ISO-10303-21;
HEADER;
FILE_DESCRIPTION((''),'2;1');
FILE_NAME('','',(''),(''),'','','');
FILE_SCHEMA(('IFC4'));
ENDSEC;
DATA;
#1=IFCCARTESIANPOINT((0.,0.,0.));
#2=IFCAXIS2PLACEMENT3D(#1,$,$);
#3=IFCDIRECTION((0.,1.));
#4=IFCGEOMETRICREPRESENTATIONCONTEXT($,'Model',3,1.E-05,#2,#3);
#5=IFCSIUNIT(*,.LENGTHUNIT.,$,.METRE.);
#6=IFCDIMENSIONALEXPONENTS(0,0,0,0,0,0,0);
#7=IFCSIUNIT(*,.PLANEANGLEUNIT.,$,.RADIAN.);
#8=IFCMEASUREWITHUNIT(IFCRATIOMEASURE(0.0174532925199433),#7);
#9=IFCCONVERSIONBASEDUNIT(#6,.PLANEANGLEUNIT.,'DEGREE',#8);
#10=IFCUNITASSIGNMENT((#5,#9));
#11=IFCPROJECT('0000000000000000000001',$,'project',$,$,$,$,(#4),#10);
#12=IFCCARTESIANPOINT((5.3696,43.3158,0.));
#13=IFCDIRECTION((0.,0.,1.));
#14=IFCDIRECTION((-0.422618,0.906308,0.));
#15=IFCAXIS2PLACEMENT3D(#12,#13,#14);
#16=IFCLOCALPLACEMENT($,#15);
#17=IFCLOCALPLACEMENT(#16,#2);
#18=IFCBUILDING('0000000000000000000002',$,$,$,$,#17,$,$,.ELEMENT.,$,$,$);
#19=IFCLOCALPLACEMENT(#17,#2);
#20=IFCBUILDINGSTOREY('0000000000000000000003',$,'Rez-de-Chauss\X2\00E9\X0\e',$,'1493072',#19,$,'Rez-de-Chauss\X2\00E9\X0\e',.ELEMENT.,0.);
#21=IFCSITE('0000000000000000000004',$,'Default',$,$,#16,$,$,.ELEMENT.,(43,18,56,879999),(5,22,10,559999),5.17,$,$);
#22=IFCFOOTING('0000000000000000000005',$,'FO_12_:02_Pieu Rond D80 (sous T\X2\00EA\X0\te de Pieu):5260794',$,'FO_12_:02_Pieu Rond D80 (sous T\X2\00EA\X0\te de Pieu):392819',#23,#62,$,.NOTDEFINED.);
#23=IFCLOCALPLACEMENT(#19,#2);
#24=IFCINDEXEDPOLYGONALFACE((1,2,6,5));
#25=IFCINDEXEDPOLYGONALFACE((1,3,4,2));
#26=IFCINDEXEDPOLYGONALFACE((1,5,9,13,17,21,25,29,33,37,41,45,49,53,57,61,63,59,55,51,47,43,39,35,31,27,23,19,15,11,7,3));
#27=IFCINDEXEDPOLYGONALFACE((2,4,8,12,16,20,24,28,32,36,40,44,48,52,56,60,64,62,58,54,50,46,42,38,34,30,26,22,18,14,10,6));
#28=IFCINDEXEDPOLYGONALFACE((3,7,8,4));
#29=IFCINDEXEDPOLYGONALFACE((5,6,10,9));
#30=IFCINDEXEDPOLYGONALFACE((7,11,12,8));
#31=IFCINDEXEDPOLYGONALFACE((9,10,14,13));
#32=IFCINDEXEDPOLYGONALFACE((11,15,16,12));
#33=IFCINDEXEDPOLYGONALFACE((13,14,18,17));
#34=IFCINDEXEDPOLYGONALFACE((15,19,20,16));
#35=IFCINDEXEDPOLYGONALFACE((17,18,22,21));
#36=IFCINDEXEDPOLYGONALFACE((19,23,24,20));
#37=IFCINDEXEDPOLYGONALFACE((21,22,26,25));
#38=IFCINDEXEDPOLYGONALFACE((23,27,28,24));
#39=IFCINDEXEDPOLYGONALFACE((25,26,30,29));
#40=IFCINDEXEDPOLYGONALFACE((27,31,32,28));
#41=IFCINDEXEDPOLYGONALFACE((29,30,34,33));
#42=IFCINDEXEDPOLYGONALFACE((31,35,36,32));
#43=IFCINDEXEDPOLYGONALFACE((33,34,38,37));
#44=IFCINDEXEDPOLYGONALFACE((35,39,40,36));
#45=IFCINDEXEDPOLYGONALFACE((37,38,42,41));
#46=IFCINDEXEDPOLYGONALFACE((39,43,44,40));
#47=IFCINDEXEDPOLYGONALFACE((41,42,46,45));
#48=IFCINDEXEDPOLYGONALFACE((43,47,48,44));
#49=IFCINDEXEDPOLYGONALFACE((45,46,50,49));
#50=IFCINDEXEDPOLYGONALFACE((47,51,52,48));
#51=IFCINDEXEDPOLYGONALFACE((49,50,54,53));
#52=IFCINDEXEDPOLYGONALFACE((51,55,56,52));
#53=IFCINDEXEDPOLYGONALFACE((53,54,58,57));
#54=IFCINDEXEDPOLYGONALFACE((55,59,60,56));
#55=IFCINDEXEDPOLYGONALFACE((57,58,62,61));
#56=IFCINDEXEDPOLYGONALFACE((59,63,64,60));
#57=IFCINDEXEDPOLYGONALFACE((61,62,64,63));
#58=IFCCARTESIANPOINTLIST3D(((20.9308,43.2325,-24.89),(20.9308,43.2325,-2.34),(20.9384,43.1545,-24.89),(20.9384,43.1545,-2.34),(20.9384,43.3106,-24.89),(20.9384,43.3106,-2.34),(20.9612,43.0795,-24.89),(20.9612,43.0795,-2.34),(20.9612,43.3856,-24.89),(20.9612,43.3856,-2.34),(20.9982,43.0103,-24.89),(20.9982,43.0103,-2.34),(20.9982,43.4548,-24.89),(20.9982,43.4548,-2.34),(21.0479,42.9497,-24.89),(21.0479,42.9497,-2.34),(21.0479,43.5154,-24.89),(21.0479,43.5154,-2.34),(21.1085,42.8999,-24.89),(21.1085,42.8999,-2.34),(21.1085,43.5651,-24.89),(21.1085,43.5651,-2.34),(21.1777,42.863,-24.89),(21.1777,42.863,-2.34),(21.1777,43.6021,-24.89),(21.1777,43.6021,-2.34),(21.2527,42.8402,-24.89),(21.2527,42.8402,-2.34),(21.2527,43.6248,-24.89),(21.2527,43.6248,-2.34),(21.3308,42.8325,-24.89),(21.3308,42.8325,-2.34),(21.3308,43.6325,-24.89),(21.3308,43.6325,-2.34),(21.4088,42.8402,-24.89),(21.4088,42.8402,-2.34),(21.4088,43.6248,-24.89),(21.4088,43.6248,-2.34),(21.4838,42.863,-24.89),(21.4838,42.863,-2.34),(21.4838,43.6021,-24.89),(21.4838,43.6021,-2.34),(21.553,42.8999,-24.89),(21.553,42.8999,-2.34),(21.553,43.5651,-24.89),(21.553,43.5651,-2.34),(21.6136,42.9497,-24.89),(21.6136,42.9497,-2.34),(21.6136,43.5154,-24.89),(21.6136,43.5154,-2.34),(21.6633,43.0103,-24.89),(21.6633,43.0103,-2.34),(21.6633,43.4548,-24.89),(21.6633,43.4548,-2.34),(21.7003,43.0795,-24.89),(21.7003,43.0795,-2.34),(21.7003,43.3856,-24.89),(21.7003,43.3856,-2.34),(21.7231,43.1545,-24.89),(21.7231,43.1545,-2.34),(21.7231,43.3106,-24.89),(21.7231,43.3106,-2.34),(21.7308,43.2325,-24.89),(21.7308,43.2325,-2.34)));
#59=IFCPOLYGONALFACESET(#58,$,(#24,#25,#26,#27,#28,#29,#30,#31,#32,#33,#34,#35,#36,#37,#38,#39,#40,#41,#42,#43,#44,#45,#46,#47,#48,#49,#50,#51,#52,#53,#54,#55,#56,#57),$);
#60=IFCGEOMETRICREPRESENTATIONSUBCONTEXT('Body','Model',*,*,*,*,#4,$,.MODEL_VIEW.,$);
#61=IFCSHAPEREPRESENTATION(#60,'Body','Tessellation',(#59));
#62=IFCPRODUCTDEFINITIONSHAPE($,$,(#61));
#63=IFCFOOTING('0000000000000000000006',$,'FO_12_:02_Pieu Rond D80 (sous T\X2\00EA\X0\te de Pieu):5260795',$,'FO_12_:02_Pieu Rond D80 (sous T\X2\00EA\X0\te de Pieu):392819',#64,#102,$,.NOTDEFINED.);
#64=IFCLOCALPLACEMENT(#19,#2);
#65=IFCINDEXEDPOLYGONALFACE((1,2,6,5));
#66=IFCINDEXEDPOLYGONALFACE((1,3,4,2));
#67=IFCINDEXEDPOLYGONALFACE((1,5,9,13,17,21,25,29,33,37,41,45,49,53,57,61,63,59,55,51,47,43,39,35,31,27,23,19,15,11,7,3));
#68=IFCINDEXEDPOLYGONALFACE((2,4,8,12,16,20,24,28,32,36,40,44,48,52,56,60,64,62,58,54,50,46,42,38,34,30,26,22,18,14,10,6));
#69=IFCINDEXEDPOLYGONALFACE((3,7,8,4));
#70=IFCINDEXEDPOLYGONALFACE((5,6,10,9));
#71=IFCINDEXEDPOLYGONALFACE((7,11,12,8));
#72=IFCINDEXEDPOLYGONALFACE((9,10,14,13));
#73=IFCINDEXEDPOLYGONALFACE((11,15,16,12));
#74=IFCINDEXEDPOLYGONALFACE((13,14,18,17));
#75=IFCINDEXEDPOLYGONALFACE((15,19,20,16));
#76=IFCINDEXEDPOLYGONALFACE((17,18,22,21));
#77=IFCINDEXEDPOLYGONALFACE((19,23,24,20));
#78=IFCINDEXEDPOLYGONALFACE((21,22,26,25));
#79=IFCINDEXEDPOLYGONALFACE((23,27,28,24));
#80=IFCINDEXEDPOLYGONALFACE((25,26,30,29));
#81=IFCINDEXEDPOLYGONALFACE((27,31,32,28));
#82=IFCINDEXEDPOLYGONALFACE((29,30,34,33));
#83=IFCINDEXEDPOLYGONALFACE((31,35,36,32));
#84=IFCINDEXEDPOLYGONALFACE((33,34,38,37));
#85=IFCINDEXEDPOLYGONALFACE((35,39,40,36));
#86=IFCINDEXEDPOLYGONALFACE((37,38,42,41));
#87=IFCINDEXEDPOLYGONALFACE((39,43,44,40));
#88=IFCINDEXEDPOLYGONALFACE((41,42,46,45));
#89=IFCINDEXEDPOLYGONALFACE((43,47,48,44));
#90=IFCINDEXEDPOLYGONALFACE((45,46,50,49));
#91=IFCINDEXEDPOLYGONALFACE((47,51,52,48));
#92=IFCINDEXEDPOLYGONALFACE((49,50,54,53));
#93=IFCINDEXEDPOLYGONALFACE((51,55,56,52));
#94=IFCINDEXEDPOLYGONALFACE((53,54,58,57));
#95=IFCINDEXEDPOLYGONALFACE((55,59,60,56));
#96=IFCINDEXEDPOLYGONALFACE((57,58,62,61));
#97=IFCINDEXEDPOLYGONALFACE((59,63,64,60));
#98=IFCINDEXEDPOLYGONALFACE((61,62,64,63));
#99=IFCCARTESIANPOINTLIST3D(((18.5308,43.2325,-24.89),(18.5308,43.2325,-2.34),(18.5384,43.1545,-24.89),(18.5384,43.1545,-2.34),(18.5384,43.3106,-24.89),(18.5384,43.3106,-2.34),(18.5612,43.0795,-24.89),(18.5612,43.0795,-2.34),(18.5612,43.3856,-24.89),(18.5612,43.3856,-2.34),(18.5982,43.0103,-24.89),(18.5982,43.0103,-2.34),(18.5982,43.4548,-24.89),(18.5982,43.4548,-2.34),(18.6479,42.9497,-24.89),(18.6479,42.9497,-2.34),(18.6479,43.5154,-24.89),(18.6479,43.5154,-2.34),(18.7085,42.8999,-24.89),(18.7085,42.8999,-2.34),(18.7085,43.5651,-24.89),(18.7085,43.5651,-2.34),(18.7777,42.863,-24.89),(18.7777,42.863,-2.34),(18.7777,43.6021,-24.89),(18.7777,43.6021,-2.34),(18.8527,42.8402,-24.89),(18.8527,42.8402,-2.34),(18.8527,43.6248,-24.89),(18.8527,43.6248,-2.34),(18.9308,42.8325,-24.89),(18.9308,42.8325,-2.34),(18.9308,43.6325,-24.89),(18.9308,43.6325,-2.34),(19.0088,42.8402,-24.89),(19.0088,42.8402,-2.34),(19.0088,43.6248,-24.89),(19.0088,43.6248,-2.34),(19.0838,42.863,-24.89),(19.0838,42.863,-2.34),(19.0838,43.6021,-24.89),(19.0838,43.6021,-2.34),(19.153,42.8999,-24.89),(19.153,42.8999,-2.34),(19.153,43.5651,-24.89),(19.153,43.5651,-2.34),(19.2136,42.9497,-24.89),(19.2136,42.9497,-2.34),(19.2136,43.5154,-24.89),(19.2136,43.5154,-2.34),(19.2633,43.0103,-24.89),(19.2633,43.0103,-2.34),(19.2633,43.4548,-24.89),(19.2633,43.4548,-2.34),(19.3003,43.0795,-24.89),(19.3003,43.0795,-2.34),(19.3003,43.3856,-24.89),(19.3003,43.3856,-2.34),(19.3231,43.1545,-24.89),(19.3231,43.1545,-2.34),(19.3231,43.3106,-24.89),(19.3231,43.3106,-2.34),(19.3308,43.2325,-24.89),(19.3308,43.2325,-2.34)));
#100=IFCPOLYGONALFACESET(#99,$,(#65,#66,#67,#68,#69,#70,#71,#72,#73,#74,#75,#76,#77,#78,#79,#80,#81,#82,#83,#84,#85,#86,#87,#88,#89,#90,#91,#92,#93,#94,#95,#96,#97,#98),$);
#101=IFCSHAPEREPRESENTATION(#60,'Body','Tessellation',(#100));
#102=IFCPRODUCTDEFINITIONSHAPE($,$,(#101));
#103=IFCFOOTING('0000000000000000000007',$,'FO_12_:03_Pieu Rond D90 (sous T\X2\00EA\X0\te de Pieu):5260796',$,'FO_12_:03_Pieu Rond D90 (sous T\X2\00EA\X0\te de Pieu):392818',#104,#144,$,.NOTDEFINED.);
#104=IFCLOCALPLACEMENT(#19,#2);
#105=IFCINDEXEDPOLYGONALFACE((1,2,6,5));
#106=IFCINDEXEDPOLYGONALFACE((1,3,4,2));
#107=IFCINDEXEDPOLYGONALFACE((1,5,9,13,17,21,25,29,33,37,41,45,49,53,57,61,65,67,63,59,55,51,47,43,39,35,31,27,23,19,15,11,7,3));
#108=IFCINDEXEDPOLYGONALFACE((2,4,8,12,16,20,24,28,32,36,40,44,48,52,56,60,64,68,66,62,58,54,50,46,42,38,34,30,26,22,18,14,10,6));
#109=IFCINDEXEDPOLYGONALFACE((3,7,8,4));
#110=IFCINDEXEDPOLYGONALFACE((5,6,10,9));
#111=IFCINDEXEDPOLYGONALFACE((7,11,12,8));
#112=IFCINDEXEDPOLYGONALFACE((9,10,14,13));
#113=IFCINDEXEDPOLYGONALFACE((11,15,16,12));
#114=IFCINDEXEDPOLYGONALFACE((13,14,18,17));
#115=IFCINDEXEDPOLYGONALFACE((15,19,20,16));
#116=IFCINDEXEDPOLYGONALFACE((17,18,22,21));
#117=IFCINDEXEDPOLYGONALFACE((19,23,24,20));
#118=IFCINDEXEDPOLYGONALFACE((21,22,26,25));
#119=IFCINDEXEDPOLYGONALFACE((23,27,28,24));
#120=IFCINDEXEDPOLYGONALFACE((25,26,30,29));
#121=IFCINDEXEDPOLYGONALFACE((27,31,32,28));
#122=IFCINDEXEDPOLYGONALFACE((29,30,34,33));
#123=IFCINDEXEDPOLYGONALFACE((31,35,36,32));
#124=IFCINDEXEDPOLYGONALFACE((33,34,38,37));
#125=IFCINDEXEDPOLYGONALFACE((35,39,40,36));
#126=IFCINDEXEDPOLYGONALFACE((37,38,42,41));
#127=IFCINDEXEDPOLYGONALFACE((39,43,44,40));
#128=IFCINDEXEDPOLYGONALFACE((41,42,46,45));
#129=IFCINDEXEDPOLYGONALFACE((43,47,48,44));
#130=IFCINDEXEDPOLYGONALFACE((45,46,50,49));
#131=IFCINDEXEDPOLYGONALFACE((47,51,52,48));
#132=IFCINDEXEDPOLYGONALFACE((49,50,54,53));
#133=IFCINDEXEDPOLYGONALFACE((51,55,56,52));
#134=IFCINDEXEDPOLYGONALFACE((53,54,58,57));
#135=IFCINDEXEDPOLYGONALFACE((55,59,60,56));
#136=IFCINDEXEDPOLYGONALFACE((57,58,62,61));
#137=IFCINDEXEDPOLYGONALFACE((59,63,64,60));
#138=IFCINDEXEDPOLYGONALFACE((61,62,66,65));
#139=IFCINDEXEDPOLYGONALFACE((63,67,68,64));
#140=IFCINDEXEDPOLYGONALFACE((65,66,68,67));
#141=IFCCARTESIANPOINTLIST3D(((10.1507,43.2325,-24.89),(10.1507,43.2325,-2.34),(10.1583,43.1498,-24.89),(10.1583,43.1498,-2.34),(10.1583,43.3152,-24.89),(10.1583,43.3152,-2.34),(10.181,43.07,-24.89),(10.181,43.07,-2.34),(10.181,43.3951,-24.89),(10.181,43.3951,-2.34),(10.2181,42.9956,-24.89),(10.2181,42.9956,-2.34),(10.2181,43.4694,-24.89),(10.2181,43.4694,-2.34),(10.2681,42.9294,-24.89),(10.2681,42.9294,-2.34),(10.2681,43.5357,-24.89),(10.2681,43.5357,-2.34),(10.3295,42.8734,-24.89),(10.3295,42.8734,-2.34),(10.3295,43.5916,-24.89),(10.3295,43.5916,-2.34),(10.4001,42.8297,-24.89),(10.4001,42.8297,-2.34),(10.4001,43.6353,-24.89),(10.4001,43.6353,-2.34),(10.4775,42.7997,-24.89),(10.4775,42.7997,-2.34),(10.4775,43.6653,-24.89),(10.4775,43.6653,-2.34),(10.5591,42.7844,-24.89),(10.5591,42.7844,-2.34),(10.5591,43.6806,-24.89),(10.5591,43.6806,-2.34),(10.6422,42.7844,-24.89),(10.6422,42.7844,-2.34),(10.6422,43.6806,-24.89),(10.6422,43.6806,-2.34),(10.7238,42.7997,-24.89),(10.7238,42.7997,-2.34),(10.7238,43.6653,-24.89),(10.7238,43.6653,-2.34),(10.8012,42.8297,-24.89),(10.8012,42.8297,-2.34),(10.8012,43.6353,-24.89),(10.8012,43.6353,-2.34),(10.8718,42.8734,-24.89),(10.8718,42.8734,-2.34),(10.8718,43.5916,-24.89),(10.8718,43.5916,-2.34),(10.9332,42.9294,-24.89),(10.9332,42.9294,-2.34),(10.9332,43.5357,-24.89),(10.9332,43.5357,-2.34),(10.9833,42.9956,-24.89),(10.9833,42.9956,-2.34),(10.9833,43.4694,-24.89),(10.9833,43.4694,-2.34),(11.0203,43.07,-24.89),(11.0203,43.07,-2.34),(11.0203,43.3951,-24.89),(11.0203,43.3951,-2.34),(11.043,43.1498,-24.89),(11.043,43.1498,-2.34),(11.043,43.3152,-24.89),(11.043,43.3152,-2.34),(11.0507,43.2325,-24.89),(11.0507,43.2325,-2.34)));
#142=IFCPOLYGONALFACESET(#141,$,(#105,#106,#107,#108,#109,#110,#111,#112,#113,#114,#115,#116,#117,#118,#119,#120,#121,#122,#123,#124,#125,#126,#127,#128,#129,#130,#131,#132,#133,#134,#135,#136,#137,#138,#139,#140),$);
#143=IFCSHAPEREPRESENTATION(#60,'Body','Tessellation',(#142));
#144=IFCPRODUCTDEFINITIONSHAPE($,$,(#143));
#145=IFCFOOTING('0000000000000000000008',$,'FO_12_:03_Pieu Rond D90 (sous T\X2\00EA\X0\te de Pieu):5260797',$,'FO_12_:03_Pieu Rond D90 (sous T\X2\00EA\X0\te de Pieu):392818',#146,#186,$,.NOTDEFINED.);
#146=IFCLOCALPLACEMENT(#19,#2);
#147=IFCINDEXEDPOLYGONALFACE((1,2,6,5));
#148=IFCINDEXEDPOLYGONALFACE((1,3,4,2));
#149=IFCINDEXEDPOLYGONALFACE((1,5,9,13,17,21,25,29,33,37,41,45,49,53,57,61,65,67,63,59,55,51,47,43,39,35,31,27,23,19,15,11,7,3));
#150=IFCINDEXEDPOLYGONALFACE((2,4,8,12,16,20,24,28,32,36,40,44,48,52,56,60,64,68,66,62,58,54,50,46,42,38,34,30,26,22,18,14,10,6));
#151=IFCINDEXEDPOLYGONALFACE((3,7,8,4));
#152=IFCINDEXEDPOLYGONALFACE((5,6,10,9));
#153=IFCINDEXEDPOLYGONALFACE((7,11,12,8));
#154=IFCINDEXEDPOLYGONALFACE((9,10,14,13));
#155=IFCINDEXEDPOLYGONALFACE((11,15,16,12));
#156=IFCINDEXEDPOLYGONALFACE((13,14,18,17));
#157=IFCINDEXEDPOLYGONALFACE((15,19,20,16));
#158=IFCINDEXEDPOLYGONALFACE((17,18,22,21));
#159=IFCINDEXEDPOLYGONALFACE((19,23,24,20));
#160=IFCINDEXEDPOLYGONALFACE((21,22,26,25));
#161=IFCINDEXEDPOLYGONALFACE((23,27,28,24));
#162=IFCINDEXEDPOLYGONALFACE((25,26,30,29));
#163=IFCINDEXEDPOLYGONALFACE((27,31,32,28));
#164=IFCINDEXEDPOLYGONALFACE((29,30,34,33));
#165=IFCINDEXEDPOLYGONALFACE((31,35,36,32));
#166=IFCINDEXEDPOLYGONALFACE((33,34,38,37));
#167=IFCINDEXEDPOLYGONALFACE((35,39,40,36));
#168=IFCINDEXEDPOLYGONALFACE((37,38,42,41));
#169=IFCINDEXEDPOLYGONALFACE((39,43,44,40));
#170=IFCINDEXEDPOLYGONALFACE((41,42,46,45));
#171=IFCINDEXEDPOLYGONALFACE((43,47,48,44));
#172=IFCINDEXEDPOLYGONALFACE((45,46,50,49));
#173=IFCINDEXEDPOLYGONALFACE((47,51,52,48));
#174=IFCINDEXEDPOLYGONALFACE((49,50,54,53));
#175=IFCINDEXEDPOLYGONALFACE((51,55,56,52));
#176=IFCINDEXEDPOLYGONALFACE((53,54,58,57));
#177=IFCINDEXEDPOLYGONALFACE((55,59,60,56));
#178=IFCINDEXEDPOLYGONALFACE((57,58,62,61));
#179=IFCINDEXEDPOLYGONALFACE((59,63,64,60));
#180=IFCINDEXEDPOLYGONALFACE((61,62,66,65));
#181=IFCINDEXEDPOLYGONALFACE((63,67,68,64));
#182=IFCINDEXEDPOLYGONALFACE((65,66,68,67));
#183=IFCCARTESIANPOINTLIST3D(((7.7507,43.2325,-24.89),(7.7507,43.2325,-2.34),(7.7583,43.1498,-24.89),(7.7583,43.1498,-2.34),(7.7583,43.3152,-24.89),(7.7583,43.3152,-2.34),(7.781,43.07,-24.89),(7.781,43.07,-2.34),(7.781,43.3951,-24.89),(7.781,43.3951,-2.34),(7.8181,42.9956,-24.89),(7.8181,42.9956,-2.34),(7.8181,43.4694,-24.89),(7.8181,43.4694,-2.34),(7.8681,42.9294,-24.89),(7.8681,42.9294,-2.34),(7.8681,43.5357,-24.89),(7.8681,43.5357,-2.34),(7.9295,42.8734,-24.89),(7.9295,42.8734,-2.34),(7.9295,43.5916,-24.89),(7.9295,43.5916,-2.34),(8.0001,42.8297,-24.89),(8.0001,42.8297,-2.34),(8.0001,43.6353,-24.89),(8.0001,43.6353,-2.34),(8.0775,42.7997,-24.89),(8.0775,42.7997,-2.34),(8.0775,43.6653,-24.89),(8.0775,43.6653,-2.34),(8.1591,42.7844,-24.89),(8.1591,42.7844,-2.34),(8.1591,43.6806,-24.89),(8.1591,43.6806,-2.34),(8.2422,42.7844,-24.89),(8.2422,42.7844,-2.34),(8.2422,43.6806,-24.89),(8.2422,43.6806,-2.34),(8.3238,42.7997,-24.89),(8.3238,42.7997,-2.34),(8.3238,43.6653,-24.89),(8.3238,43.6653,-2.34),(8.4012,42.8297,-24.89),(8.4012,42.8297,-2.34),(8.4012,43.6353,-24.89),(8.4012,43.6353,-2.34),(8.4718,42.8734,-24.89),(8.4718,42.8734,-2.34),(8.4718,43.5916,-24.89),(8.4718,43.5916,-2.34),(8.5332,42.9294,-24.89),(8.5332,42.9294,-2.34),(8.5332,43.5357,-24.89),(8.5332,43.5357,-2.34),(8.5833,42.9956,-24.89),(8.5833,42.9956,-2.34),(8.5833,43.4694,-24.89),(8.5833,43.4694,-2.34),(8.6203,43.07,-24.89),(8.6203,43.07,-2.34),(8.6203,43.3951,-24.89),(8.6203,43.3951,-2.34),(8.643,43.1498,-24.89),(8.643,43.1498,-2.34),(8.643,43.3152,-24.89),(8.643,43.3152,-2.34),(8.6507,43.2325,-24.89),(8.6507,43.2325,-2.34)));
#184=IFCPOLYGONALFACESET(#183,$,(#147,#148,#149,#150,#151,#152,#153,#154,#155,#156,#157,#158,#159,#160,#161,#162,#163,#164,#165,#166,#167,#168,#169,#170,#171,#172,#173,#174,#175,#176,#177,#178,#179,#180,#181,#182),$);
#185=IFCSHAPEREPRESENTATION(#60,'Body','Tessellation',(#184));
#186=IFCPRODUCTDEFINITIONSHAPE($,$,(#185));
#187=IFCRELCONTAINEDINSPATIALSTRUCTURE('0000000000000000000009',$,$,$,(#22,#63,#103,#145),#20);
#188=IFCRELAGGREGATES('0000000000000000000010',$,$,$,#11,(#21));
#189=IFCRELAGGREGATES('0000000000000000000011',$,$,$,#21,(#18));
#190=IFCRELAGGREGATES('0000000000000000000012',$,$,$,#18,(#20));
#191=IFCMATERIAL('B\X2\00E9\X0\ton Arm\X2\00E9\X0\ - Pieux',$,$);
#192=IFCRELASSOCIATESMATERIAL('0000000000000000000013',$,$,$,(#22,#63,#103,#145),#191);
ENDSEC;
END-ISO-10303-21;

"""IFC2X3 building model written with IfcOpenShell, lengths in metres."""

from ifc_helpers import new_model, entity, si_unit, converted_unit, direction, frame, frame_2d, origin, origin_2d_with_axis, place, context, subcontext, project, spatial, circle, extrude, material, element, save


model = new_model("IFC2X3")

# Units and contexts
model_context = context("Model", 3, precision=1e-05, world=origin(), true_north=direction((0.0, 1.0)))
body_context = subcontext(model_context, "Body", "Model", "MODEL_VIEW")
ifc_project = project(units=[si_unit("LENGTHUNIT", "METRE"), converted_unit("PLANEANGLEUNIT", "DEGREE", entity("IfcRatioMeasure", 0.0174532925199433), si_unit("PLANEANGLEUNIT", "RADIAN"), dimensions=[0, 0, 0, 0, 0, 0, 0])], contexts=[model_context])

# Site, building, storey
site_placement = place(None, frame((5.3696, 43.3158, 0.0), z_axis=(0.0, 0.0, 1.0), x_axis=(-0.422618, 0.906308, 0.0)))
site = spatial("IfcSite", under=ifc_project, at=site_placement, Name="Default", CompositionType="ELEMENT", RefLatitude=(43, 18, 56, 879999), RefLongitude=(5, 22, 10, 559999), RefElevation=5.17)
building_placement = place(site_placement, origin())
building = spatial("IfcBuilding", under=site, at=building_placement, CompositionType="ELEMENT")
storey_placement = place(building_placement, origin())
storey = spatial("IfcBuildingStorey", under=building, at=storey_placement, Name="Rez-de-Chaussée", ObjectType="1493072", LongName="Rez-de-Chaussée", CompositionType="ELEMENT", Elevation=0.0)

# Footings
ifc_material_1 = material(Name="Béton Armé - Pieux")
footing_1_placement = place(storey_placement, origin())
element("IfcFooting", 1, at=footing_1_placement, inside=storey, material=ifc_material_1, Name="FO_12_:02_Pieu Rond D80 (sous Tête de Pieu):5260794", ObjectType="FO_12_:02_Pieu Rond D80 (sous Tête de Pieu):392819", PredefinedType="NOTDEFINED", context=body_context, shape_type="SweptSolid", body=[
    extrude(circle(Radius=0.4, at=origin_2d_with_axis()), frame((21.3308, 43.2325, -24.89), z_axis=(0.0, 0.0, 1.0), x_axis=(-1.0, 0.0, 0.0)), (0.0, 0.0, 1.0), 22.55),
])
footing_2_placement = place(storey_placement, origin())
element("IfcFooting", 2, at=footing_2_placement, inside=storey, material=ifc_material_1, Name="FO_12_:02_Pieu Rond D80 (sous Tête de Pieu):5260795", ObjectType="FO_12_:02_Pieu Rond D80 (sous Tête de Pieu):392819", PredefinedType="NOTDEFINED", context=body_context, shape_type="SweptSolid", body=[
    extrude(circle(Radius=0.4, at=origin_2d_with_axis()), frame((18.9308, 43.2325, -24.89), z_axis=(0.0, 0.0, 1.0), x_axis=(-1.0, 0.0, 0.0)), (0.0, 0.0, 1.0), 22.55),
])
footing_3_placement = place(storey_placement, origin())
element("IfcFooting", 3, at=footing_3_placement, inside=storey, material=ifc_material_1, Name="FO_12_:03_Pieu Rond D90 (sous Tête de Pieu):5260796", ObjectType="FO_12_:03_Pieu Rond D90 (sous Tête de Pieu):392818", PredefinedType="NOTDEFINED", context=body_context, shape_type="SweptSolid", body=[
    extrude(circle(Radius=0.45, at=frame_2d((0.0, 0.0), x_axis=(1.0, 0.0))), frame((10.6007, 43.2325, -24.89), z_axis=(0.0, 0.0, 1.0), x_axis=(-1.0, 0.0, 0.0)), (0.0, 0.0, 1.0), 22.55),
])
footing_4_placement = place(storey_placement, origin())
element("IfcFooting", 4, at=footing_4_placement, inside=storey, material=ifc_material_1, Name="FO_12_:03_Pieu Rond D90 (sous Tête de Pieu):5260797", ObjectType="FO_12_:03_Pieu Rond D90 (sous Tête de Pieu):392818", PredefinedType="NOTDEFINED", context=body_context, shape_type="SweptSolid", body=[
    extrude(circle(Radius=0.45, at=frame_2d((0.0, 0.0), x_axis=(1.0, 0.0))), frame((8.2007, 43.2325, -24.89), z_axis=(0.0, 0.0, 1.0), x_axis=(-1.0, 0.0, 0.0)), (0.0, 0.0, 1.0), 22.55),
])

save(model, "model.ifc")
